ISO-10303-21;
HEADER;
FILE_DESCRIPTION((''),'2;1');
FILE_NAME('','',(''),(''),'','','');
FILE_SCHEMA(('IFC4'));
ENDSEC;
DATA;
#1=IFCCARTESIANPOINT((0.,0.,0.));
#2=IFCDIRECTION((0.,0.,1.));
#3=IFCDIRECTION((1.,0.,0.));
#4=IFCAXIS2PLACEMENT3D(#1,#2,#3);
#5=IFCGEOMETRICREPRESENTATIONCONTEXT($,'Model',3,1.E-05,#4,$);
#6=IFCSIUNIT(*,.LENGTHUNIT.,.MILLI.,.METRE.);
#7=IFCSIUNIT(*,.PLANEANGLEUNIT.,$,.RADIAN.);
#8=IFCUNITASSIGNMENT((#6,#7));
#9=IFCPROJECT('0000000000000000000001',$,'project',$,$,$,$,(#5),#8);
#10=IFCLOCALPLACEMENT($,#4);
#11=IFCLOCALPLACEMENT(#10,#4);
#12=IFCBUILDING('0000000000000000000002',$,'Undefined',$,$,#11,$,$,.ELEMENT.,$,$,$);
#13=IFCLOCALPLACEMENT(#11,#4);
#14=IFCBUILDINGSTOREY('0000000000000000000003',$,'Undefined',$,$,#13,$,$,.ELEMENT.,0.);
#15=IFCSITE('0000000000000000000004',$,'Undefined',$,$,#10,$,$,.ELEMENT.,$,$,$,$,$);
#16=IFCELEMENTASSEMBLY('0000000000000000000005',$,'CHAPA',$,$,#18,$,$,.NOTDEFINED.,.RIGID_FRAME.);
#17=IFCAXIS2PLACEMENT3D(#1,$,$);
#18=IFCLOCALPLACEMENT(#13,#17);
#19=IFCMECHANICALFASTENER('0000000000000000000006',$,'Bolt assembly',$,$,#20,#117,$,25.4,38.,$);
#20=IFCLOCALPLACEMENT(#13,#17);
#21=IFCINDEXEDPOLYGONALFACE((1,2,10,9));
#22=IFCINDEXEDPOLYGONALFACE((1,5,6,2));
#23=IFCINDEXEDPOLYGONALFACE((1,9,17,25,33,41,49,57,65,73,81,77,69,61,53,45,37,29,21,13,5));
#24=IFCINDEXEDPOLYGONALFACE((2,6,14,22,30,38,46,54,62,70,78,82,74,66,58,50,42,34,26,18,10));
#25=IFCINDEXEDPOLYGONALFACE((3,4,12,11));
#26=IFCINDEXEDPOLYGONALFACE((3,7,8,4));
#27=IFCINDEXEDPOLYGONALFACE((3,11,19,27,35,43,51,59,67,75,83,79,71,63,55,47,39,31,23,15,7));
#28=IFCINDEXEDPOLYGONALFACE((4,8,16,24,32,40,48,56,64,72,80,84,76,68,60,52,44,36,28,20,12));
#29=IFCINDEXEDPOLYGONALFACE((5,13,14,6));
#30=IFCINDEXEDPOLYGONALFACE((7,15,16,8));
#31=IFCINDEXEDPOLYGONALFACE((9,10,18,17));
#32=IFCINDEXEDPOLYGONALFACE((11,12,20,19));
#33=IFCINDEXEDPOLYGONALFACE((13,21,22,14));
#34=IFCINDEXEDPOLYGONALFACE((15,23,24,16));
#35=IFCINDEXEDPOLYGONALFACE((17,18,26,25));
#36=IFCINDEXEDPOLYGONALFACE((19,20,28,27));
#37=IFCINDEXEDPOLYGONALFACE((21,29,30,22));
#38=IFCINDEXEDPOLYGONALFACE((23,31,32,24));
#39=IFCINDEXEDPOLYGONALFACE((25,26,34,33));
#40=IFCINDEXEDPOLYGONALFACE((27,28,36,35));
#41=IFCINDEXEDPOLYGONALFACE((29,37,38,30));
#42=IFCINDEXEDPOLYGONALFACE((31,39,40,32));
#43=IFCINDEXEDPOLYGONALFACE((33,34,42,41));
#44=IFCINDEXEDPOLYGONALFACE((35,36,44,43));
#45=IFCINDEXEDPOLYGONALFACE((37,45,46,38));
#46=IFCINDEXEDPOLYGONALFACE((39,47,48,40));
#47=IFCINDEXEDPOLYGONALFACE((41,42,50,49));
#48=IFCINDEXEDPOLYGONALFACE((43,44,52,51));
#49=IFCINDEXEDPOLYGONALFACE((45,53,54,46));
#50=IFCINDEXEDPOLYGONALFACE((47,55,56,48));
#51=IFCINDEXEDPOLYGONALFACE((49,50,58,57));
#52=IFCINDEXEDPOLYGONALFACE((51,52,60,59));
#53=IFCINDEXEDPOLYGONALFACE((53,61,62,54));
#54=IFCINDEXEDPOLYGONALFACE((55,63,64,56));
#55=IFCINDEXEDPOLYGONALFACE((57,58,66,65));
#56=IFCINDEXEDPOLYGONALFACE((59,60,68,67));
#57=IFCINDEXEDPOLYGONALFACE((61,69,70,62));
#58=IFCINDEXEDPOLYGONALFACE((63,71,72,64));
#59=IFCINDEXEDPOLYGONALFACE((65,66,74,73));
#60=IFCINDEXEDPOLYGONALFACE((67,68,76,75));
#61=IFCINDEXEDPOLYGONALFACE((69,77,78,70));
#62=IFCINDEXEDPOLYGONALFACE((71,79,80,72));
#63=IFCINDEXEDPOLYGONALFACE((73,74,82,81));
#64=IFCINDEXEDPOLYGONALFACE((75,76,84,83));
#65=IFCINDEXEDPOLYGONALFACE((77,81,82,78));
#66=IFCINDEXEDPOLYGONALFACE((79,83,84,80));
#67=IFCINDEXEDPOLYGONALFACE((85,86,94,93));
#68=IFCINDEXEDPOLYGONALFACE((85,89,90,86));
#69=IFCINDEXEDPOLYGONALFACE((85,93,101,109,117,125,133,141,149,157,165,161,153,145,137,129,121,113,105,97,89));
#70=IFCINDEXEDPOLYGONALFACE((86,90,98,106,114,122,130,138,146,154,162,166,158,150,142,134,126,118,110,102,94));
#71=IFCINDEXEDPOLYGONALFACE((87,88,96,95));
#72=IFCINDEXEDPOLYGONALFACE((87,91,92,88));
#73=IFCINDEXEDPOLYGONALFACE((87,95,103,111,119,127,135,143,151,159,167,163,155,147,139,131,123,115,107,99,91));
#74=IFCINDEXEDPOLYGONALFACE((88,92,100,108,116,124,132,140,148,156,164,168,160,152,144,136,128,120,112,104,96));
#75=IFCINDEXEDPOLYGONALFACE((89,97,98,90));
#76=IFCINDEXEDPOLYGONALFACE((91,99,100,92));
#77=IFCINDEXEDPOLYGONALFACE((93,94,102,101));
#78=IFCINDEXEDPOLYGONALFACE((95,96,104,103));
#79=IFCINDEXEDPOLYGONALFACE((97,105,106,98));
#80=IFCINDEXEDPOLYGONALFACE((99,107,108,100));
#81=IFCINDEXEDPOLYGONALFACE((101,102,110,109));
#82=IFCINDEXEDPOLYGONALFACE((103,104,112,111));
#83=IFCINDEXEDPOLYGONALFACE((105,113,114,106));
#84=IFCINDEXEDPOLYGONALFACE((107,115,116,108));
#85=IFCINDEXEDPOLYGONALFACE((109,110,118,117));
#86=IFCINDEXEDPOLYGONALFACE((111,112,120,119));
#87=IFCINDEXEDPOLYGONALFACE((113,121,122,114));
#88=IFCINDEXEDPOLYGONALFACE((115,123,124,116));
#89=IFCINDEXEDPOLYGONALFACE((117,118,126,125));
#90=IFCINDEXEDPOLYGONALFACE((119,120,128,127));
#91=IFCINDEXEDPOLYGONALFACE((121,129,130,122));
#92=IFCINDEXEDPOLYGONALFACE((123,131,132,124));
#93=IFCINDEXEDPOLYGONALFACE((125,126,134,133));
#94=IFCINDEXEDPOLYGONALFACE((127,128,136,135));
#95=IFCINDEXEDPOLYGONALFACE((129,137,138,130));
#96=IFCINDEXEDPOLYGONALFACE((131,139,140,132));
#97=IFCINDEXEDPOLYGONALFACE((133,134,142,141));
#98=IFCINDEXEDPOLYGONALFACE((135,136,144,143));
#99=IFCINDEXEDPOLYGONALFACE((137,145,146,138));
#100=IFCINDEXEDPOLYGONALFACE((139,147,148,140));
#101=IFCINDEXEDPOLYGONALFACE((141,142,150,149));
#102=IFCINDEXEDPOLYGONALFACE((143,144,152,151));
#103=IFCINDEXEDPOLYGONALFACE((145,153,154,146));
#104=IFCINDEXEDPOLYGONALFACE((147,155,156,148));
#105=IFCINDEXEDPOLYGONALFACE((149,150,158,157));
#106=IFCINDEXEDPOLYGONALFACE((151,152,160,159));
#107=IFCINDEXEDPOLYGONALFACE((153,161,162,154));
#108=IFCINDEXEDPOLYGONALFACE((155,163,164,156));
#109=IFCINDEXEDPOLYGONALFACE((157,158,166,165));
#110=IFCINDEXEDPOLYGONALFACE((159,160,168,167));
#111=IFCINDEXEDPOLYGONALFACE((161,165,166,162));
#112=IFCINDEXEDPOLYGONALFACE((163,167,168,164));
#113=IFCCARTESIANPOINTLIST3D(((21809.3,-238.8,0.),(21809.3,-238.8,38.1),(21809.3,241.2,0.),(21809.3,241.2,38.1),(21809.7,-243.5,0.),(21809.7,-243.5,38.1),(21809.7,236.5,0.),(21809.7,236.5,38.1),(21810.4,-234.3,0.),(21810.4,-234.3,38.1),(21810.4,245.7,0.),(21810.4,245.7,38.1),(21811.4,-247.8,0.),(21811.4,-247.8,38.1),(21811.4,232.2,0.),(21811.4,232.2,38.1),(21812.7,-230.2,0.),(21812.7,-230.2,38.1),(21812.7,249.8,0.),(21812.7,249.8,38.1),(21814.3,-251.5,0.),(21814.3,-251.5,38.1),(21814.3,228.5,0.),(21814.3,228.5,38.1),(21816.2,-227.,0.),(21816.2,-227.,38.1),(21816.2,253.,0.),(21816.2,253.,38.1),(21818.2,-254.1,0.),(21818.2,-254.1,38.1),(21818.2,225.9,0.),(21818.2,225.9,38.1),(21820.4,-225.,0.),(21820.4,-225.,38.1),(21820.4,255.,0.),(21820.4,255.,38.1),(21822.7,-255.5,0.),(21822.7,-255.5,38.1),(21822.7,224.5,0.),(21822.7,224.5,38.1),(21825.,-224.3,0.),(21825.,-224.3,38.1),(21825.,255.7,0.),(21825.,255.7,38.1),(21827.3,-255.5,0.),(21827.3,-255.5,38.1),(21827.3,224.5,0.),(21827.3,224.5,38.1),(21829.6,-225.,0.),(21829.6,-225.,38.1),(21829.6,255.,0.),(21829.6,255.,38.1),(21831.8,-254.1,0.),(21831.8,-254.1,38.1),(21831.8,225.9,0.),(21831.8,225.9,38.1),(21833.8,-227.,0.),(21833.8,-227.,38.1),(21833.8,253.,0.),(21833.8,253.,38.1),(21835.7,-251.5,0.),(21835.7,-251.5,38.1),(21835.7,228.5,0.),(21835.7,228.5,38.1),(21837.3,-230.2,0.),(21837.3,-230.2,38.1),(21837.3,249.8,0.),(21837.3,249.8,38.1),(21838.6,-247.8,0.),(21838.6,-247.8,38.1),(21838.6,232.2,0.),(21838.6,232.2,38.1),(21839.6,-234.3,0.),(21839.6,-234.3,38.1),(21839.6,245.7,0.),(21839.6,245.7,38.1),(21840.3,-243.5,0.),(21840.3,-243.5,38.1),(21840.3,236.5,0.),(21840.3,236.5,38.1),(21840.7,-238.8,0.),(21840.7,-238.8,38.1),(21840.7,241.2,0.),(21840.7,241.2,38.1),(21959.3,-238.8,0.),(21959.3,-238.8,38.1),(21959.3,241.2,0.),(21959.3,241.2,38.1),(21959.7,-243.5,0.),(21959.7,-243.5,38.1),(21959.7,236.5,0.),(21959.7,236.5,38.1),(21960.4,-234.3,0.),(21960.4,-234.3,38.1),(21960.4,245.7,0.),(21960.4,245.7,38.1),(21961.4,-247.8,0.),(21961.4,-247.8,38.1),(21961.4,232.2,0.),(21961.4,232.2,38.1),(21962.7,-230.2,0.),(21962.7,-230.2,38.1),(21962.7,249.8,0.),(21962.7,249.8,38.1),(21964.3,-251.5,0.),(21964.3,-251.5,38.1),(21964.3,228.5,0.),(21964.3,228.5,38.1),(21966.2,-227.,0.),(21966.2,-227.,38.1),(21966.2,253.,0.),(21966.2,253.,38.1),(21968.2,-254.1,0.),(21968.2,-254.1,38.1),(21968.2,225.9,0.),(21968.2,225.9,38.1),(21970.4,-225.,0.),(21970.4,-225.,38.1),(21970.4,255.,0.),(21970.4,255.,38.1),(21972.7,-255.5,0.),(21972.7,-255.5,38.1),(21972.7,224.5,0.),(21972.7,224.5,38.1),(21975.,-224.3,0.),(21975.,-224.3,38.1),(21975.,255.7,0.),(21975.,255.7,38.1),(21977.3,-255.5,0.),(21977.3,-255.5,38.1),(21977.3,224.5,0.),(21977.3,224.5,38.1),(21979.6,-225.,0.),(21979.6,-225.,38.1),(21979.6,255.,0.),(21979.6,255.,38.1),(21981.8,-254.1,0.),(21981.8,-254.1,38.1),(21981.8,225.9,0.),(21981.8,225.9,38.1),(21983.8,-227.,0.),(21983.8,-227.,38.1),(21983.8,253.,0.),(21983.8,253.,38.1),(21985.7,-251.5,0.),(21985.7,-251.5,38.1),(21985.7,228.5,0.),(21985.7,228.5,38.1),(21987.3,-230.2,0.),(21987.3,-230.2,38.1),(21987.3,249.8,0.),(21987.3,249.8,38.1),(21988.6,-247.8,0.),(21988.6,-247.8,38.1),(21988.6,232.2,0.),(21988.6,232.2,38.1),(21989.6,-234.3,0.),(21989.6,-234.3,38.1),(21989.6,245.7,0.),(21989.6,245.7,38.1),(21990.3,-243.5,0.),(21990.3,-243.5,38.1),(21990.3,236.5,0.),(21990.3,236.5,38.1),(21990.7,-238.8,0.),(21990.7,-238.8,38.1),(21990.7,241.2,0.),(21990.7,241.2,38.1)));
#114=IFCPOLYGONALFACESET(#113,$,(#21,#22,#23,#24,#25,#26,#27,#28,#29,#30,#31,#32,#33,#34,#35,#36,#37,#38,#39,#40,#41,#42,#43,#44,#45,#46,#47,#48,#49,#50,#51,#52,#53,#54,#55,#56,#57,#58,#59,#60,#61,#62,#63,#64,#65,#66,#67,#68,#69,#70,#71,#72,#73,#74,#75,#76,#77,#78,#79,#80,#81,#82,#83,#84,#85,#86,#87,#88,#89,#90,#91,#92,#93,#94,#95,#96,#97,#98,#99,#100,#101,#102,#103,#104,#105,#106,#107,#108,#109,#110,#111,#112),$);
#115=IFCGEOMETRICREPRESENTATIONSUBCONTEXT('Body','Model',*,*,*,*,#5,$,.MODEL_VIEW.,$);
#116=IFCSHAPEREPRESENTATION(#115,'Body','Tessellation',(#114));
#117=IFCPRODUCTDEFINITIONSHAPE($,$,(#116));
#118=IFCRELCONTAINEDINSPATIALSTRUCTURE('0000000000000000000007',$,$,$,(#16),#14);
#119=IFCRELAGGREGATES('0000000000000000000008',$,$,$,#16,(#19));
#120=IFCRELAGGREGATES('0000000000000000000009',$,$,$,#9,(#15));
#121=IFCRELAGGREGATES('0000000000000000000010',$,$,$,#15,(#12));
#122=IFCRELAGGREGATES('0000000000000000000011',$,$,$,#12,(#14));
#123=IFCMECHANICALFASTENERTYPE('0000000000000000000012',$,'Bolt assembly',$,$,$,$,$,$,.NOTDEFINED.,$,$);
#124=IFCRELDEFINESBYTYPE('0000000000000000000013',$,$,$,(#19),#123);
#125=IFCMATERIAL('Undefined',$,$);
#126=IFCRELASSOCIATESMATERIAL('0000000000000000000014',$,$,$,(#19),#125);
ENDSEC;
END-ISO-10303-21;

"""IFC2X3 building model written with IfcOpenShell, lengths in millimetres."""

from ifc_helpers import new_model, si_unit, frame, origin_with_axes, origin_2d_with_axis, place, context, subcontext, project, spatial, circle, extrude, source, transform, mapped, material, type_object, element, aggregate, save


model = new_model("IFC2X3")

# Units and contexts
model_context = context("Model", 3, precision=1e-05, world=origin_with_axes())
body_context = subcontext(model_context, "Body", "Model", "MODEL_VIEW")
ifc_project = project(units=[si_unit("LENGTHUNIT", "METRE", prefix="MILLI"), si_unit("PLANEANGLEUNIT", "RADIAN")], contexts=[model_context])

# Site, building, storey
site_placement = place(None, origin_with_axes())
site = spatial("IfcSite", under=ifc_project, at=site_placement, Name="Undefined", CompositionType="ELEMENT")
building_placement = place(site_placement, origin_with_axes())
building = spatial("IfcBuilding", under=site, at=building_placement, Name="Undefined", CompositionType="ELEMENT")
storey_placement = place(building_placement, origin_with_axes())
storey = spatial("IfcBuildingStorey", under=building, at=storey_placement, Name="Undefined", CompositionType="ELEMENT", Elevation=0.0)

# Element assembly
assembly_1_placement = place(storey_placement, origin_with_axes())
assembly_1 = element("IfcElementAssembly", 1, at=assembly_1_placement, inside=storey, Name="CHAPA", AssemblyPlace="NOTDEFINED", PredefinedType="RIGID_FRAME")

# Shared definitions
ifc_material_1 = material(Name="Undefined")
mechanical_fastener_type = type_object("IfcMechanicalFastenerType", Name="Bolt assembly")

# Mechanical fastener
shared_shape_1 = source(origin_with_axes(), body_context, "Body", "SweptSolid", [
    extrude(circle(Radius=15.7, at=origin_2d_with_axis()), frame((0.0, -38.0, 0.0), z_axis=(0.0, 1.0, 0.0), x_axis=(1.0, 0.0, 0.0)), (0.0, 0.0, 1.0), 38.1),
])
mechanical_fastener_1_placement = place(assembly_1_placement, frame((21900.0, -240.0, 38.0), z_axis=(1.0, 0.0, 0.0), x_axis=(0.0, 1.0, 0.0)))
mechanical_fastener_1 = element("IfcMechanicalFastener", 2, at=mechanical_fastener_1_placement, type_object=mechanical_fastener_type, material=ifc_material_1, Name="Bolt assembly", NominalDiameter=25.4, NominalLength=38.0, context=body_context, shape_type="MappedRepresentation", body=[
    mapped(shared_shape_1, transform((0.0, 0.0, -75.0))),
    mapped(shared_shape_1, transform((0.0, 0.0, 75.0))),
    mapped(shared_shape_1, transform((480.0, 0.0, -75.0))),
    mapped(shared_shape_1, transform((480.0, 0.0, 75.0))),
])
aggregate(assembly_1, [mechanical_fastener_1])

save(model, "model.ifc")
